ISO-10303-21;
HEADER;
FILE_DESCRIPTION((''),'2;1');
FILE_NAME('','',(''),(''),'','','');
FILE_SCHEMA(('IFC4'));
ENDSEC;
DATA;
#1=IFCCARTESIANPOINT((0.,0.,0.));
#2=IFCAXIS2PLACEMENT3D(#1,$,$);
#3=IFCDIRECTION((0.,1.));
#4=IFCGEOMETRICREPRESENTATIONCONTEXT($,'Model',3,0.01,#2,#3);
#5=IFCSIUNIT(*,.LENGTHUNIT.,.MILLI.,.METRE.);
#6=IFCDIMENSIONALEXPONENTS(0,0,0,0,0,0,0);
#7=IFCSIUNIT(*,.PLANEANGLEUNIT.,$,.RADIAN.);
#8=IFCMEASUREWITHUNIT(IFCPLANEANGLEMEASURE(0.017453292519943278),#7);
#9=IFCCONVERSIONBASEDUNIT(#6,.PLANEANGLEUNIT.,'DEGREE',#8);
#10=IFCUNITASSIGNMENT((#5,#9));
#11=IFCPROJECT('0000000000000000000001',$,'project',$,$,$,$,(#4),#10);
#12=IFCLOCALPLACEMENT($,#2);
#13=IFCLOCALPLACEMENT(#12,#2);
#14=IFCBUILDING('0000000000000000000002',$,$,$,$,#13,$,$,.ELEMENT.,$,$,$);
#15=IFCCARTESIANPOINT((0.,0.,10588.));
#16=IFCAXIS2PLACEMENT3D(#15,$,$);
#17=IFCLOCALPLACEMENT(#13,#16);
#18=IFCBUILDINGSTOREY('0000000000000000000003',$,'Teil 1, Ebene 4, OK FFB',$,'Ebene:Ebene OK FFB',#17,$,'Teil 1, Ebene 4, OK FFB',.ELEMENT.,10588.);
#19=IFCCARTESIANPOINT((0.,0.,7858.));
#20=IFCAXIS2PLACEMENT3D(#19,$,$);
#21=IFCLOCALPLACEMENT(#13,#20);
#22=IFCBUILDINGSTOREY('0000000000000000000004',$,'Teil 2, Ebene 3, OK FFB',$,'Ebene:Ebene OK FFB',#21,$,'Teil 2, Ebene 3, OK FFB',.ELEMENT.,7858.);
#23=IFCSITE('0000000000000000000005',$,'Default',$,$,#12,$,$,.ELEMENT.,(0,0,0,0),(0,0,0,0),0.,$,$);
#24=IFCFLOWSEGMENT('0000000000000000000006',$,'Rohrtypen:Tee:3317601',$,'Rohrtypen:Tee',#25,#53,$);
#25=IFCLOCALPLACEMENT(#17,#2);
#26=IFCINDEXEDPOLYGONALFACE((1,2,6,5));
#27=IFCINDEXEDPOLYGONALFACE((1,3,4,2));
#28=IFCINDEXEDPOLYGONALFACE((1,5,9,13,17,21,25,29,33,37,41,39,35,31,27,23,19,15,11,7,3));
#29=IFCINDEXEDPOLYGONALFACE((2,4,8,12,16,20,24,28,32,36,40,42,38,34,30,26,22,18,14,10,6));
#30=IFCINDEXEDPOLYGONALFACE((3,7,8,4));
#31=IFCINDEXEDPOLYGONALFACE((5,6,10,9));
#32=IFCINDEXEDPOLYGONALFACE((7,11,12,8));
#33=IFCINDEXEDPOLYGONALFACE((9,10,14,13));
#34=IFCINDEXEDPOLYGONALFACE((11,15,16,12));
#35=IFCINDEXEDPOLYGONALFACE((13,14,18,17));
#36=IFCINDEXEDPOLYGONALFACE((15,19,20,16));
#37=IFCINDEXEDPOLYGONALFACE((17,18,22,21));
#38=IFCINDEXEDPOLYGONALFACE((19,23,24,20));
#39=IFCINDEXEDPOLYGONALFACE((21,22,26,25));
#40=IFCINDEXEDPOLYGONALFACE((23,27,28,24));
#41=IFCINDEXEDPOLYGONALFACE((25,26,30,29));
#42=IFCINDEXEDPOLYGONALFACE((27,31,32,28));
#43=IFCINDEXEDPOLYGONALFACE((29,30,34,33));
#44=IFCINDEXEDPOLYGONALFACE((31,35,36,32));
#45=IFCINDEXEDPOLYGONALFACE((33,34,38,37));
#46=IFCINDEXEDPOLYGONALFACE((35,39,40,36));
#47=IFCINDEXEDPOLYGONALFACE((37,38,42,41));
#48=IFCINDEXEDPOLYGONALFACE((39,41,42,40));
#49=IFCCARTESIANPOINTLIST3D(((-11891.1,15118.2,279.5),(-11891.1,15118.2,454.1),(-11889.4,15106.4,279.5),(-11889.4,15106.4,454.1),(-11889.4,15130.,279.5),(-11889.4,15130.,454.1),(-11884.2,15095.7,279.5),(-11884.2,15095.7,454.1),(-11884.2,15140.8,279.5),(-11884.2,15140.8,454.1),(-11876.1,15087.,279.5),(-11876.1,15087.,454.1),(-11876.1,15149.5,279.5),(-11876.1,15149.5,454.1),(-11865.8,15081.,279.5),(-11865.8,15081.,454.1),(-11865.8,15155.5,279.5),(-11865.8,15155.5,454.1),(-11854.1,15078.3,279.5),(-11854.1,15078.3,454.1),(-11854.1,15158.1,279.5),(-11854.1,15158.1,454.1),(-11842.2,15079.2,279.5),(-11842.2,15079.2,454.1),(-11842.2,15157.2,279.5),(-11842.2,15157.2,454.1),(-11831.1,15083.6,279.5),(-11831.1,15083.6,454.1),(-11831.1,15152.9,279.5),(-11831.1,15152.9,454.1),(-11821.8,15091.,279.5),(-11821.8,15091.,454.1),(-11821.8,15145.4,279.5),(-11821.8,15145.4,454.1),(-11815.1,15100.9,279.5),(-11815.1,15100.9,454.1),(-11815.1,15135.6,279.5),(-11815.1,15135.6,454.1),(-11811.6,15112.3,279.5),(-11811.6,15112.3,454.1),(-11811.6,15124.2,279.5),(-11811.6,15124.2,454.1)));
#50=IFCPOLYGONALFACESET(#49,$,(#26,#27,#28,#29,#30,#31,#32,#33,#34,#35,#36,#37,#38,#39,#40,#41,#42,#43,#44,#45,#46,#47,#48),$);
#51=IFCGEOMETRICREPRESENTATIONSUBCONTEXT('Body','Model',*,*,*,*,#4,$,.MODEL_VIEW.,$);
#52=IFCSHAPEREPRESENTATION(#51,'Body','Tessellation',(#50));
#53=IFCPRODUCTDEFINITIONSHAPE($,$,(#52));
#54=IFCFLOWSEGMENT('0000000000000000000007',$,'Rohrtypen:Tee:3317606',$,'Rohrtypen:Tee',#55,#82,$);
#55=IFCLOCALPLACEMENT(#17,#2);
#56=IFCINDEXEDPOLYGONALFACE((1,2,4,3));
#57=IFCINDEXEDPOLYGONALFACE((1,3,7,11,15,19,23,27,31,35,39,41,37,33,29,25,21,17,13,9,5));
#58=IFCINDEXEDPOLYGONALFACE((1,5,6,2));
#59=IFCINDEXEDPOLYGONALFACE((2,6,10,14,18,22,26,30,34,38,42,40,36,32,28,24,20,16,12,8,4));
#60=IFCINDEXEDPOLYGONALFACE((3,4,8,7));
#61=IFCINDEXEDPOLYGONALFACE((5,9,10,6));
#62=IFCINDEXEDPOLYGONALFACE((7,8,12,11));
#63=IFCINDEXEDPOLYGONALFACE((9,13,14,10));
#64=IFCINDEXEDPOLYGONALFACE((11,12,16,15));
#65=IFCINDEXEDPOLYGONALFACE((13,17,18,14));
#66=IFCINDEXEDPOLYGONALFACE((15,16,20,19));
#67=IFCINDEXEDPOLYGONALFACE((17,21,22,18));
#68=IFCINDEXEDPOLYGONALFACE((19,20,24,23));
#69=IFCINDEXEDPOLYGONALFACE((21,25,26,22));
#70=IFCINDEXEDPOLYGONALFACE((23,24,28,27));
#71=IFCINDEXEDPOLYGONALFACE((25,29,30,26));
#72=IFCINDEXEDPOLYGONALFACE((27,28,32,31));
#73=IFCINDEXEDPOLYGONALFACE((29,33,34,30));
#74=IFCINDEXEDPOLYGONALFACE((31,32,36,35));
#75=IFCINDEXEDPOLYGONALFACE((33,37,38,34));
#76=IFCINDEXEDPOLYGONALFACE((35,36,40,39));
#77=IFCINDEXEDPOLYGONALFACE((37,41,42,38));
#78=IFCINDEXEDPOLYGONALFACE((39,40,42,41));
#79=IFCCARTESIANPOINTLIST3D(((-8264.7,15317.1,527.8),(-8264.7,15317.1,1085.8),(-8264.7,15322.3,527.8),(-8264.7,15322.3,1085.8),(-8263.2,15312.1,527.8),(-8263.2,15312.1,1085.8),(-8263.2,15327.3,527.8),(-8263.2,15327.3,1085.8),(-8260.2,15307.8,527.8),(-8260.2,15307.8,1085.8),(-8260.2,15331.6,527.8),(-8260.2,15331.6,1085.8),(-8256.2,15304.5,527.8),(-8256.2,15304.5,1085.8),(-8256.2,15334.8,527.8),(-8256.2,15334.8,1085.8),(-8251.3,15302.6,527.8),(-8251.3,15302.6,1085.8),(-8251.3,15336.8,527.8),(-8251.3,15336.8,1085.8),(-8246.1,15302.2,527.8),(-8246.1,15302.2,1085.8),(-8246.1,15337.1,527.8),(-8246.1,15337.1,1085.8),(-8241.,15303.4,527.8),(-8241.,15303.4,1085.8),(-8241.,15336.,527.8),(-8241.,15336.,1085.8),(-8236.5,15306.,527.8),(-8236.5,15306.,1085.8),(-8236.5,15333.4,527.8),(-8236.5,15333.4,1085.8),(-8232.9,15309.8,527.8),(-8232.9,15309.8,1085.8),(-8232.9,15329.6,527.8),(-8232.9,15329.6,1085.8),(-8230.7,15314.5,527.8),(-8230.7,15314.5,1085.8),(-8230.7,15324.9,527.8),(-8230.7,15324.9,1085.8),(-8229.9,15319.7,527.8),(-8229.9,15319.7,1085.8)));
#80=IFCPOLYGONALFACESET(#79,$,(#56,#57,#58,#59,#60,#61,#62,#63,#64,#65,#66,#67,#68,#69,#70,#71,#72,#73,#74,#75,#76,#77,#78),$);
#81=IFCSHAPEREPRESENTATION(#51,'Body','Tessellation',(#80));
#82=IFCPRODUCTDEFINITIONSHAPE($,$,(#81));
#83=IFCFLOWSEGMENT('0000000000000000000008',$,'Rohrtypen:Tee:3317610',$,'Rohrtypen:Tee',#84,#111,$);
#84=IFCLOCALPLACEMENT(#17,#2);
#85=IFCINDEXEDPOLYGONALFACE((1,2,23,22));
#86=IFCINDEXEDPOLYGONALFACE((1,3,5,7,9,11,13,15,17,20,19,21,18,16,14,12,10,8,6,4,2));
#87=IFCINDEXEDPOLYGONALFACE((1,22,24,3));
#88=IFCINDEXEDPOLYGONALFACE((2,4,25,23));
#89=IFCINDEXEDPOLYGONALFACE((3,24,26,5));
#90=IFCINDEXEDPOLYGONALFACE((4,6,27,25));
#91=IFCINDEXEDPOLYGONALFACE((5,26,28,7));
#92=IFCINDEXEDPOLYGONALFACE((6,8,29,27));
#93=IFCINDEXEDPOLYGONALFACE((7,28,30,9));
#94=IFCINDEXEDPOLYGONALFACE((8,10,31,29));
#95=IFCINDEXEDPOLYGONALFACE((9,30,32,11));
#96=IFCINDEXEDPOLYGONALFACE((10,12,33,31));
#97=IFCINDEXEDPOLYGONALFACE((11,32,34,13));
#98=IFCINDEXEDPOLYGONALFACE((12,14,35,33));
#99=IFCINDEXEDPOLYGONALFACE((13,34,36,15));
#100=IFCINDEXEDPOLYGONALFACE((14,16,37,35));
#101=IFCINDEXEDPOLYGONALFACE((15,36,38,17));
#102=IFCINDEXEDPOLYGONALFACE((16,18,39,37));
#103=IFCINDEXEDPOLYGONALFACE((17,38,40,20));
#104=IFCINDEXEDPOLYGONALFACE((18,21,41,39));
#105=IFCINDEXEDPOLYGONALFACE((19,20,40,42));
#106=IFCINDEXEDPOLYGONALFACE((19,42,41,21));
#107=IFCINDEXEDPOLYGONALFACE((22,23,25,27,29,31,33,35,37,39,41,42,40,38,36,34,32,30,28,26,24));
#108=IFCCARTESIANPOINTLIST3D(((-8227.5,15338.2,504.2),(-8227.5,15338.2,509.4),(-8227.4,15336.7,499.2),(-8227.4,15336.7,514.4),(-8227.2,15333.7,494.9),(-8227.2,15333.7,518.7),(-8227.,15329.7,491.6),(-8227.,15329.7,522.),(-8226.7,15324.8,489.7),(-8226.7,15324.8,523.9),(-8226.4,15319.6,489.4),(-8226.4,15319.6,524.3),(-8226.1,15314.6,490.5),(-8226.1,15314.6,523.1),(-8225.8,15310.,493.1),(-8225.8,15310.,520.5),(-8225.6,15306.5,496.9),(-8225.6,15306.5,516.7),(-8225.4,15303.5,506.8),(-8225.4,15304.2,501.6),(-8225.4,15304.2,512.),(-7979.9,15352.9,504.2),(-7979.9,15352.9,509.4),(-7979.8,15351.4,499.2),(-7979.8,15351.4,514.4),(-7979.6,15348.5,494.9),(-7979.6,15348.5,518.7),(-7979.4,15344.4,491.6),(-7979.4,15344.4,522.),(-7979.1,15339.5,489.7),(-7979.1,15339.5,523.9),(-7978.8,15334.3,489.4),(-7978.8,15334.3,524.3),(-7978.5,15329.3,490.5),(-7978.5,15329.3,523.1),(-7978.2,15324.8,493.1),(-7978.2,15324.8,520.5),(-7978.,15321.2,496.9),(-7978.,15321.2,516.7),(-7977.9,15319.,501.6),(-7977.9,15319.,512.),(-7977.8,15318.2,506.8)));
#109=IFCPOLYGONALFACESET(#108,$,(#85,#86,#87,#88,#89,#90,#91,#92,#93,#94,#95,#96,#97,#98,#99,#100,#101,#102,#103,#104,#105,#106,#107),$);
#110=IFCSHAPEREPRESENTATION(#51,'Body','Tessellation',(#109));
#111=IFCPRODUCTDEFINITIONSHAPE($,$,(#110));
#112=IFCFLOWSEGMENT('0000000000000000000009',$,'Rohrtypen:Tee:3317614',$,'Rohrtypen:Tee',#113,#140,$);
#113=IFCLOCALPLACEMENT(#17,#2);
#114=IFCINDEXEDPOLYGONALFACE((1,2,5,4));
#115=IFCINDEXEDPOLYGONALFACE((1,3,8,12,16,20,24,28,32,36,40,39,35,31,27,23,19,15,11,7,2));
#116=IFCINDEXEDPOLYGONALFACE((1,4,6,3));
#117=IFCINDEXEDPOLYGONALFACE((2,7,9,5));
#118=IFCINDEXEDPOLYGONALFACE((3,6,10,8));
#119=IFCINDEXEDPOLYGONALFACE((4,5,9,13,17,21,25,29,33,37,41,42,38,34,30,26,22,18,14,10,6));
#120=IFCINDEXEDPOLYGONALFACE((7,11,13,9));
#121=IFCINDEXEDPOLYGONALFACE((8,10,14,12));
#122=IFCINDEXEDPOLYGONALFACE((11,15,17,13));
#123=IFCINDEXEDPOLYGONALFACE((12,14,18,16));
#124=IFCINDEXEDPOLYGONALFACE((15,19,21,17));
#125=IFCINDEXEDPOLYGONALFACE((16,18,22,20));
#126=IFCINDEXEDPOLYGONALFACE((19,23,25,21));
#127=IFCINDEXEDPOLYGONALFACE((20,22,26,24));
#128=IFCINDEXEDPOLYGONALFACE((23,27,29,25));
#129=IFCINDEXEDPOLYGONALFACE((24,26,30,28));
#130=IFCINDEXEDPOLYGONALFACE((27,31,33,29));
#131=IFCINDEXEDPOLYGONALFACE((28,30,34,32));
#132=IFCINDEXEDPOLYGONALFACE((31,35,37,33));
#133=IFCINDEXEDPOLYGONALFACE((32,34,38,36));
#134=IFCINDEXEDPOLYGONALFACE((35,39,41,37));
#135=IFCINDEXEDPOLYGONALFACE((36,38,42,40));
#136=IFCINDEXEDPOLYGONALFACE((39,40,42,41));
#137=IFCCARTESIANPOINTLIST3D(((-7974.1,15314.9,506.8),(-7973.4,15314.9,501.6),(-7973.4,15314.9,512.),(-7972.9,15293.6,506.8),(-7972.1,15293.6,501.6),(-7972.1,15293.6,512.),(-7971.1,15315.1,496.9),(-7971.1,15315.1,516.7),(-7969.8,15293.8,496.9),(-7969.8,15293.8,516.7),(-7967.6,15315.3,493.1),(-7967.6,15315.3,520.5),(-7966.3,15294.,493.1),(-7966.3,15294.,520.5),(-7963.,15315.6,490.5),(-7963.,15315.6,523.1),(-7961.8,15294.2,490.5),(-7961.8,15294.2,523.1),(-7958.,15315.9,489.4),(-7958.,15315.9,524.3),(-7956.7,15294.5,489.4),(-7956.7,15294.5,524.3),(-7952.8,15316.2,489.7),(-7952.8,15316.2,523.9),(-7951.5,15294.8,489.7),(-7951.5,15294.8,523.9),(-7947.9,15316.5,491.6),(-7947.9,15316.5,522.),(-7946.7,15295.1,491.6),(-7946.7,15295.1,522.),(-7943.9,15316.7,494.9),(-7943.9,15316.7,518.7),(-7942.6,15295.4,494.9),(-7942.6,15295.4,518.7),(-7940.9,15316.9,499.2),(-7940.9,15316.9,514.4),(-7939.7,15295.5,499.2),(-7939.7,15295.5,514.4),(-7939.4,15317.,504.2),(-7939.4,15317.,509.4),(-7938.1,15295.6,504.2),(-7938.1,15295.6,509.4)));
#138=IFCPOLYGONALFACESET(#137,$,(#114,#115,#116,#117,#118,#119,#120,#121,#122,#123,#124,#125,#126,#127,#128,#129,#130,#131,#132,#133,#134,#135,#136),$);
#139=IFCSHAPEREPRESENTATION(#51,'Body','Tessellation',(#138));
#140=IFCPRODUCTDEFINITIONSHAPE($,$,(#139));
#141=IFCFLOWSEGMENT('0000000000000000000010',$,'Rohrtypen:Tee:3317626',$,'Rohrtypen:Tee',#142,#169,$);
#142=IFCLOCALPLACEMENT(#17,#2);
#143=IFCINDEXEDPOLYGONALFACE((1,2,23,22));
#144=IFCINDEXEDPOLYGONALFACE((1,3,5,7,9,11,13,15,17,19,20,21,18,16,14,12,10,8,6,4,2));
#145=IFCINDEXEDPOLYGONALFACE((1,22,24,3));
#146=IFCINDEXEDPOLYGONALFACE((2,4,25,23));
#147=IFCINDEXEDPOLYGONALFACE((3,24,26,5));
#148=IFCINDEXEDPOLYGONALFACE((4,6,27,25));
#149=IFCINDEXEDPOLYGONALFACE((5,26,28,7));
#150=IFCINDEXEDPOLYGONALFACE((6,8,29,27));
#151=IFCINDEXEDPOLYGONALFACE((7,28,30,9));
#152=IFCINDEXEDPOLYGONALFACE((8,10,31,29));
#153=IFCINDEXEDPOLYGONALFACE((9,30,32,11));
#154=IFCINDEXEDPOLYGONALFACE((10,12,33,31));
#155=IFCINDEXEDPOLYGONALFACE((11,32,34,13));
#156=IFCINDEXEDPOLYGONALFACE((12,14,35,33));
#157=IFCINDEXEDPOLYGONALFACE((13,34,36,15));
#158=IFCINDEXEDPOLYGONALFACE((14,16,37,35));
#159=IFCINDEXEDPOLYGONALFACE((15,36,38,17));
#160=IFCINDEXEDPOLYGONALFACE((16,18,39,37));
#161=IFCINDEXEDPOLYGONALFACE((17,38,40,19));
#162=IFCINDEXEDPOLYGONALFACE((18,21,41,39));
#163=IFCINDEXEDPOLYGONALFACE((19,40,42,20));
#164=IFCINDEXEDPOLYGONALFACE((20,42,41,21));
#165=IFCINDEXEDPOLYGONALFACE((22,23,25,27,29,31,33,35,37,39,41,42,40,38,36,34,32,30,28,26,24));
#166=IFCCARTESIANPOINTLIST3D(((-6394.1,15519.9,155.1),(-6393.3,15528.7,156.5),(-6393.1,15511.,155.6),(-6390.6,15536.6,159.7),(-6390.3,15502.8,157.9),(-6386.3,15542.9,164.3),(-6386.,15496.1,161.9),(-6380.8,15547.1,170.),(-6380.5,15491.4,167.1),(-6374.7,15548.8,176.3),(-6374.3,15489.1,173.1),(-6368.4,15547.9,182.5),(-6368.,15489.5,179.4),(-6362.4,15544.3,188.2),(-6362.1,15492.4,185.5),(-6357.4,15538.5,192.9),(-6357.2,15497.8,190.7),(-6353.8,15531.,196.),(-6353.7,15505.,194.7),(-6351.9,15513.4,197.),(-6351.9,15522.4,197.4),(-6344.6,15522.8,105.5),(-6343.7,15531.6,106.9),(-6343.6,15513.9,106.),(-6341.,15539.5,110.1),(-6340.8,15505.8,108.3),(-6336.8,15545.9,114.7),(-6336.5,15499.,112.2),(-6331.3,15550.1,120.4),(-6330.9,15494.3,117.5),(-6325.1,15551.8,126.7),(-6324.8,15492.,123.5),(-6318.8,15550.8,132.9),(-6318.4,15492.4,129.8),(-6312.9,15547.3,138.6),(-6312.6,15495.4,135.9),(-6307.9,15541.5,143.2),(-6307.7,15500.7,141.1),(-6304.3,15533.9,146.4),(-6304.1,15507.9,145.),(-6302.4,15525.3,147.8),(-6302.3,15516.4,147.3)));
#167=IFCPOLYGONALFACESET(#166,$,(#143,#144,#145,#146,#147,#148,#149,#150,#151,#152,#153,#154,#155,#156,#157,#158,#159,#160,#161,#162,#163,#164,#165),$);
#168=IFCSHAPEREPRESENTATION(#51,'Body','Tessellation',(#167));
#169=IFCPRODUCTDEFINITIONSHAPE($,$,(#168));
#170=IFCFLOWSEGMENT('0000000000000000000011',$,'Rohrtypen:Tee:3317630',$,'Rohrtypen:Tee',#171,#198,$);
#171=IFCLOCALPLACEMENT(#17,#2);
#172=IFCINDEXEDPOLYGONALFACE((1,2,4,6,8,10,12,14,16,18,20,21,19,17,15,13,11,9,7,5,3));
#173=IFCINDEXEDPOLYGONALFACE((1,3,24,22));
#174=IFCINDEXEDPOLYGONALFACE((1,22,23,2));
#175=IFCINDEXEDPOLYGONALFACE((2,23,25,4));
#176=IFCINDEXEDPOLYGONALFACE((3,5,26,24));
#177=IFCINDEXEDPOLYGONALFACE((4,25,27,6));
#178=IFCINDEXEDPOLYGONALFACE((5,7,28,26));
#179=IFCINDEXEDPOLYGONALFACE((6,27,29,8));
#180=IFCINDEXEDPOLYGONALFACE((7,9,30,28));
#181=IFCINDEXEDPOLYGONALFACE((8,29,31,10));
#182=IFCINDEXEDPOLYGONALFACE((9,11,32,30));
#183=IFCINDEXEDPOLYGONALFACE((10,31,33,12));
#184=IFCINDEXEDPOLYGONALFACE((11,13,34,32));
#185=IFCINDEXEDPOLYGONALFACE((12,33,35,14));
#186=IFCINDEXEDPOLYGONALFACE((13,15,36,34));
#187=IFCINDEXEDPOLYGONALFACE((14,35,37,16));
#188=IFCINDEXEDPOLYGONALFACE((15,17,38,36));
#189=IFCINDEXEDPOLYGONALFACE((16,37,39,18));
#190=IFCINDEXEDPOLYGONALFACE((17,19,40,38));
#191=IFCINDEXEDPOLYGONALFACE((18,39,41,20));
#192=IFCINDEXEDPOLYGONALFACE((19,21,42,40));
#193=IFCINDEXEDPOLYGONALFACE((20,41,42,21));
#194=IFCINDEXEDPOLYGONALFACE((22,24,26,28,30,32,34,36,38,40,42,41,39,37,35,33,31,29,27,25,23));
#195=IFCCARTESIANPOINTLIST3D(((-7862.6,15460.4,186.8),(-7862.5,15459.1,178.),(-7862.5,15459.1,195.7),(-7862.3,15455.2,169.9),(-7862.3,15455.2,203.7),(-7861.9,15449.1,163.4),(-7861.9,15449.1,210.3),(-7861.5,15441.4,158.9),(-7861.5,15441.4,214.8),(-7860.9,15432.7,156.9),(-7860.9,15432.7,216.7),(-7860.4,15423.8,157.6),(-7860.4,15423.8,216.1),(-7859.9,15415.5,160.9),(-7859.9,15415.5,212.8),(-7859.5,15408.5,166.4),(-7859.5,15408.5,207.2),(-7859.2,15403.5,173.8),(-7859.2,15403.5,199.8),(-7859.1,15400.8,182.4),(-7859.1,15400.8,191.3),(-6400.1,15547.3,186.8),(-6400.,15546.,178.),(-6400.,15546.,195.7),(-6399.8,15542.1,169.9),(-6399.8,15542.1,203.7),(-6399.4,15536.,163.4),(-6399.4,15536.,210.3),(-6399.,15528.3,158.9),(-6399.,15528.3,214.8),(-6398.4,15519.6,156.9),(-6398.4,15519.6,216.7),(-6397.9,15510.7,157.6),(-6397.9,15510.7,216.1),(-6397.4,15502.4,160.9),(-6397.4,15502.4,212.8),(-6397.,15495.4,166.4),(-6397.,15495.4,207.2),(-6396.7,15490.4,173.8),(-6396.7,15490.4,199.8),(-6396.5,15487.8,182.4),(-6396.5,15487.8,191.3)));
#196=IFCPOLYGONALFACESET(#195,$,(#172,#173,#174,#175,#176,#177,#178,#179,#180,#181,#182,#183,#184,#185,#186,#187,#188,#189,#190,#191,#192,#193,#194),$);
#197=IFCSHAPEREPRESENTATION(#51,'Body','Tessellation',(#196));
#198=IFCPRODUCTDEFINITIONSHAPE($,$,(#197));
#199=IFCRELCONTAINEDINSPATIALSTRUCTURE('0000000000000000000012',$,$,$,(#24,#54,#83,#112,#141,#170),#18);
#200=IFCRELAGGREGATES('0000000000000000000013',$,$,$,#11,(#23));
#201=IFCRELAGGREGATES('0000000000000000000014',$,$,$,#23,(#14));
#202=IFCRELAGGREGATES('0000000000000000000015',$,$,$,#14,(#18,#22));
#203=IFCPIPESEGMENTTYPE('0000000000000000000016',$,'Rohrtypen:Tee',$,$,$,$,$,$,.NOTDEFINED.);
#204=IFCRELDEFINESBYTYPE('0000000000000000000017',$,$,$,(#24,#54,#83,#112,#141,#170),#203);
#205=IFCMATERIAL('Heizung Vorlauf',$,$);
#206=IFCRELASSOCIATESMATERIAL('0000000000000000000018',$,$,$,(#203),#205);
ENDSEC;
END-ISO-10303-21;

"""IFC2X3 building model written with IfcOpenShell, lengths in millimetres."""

from ifc_helpers import new_model, entity, si_unit, converted_unit, direction, frame, frame_2d, origin, origin_2d_with_axis, place, context, subcontext, project, spatial, circle, extrude, material, type_object, element, save


model = new_model("IFC2X3")

# Units and contexts
model_context = context("Model", 3, precision=0.01, world=origin(), true_north=direction((0.0, 1.0)))
body_context = subcontext(model_context, "Body", "Model", "MODEL_VIEW")
ifc_project = project(units=[si_unit("LENGTHUNIT", "METRE", prefix="MILLI"), converted_unit("PLANEANGLEUNIT", "DEGREE", entity("IfcPlaneAngleMeasure", 0.017453292519943278), si_unit("PLANEANGLEUNIT", "RADIAN"), dimensions=[0, 0, 0, 0, 0, 0, 0])], contexts=[model_context])

# Site, building, storey
site_placement = place(None, origin())
site = spatial("IfcSite", under=ifc_project, at=site_placement, Name="Default", CompositionType="ELEMENT", RefLatitude=(0, 0, 0, 0), RefLongitude=(0, 0, 0, 0), RefElevation=0.0)
building_placement = place(site_placement, origin())
building = spatial("IfcBuilding", under=site, at=building_placement, CompositionType="ELEMENT")
storey_1_placement = place(building_placement, frame((0.0, 0.0, 10588.0)))
storey_1 = spatial("IfcBuildingStorey", under=building, at=storey_1_placement, Name="Teil 1, Ebene 4, OK FFB", ObjectType="Ebene:Ebene OK FFB", LongName="Teil 1, Ebene 4, OK FFB", CompositionType="ELEMENT", Elevation=10588.0)

# Shared definitions
storey_2_placement = place(building_placement, frame((0.0, 0.0, 7858.0)))
storey_2 = spatial("IfcBuildingStorey", under=building, at=storey_2_placement, Name="Teil 2, Ebene 3, OK FFB", ObjectType="Ebene:Ebene OK FFB", LongName="Teil 2, Ebene 3, OK FFB", CompositionType="ELEMENT", Elevation=7858.0)

# Flow segments
ifc_material_1 = material(Name="Heizung Vorlauf")
pipe_segment_type = type_object("IfcPipeSegmentType", Name="Rohrtypen:Tee", PredefinedType="NOTDEFINED", material=ifc_material_1)
flow_segment_1_placement = place(storey_1_placement, origin())
element("IfcFlowSegment", 1, at=flow_segment_1_placement, inside=storey_1, type_object=pipe_segment_type, Name="Rohrtypen:Tee:3317601", ObjectType="Rohrtypen:Tee", context=body_context, shape_type="SweptSolid", body=[
    extrude(circle(Radius=40.0, at=origin_2d_with_axis()), frame((-11851.1, 15118.2, 279.5), z_axis=(0.0, 0.0, 1.0), x_axis=(-1.0, 0.0, 0.0)), (0.0, 0.0, 1.0), 174.6),
])
flow_segment_2_placement = place(storey_1_placement, origin())
element("IfcFlowSegment", 2, at=flow_segment_2_placement, inside=storey_1, type_object=pipe_segment_type, Name="Rohrtypen:Tee:3317606", ObjectType="Rohrtypen:Tee", context=body_context, shape_type="SweptSolid", body=[
    extrude(circle(Radius=17.5, at=origin_2d_with_axis()), frame((-8247.4, 15319.7, 527.8)), (0.0, 0.0, 1.0), 558.0),
])
flow_segment_3_placement = place(storey_1_placement, origin())
element("IfcFlowSegment", 3, at=flow_segment_3_placement, inside=storey_1, type_object=pipe_segment_type, Name="Rohrtypen:Tee:3317610", ObjectType="Rohrtypen:Tee", context=body_context, shape_type="SweptSolid", body=[
    extrude(circle(Radius=17.5, at=origin_2d_with_axis()), frame((-8226.4, 15320.9, 506.8), z_axis=(0.998239, 0.059319, 0.0), x_axis=(0.059319, -0.998239, 0.0)), (0.0, 0.0, 1.0), 248.0),
])
flow_segment_4_placement = place(storey_1_placement, origin())
element("IfcFlowSegment", 4, at=flow_segment_4_placement, inside=storey_1, type_object=pipe_segment_type, Name="Rohrtypen:Tee:3317614", ObjectType="Rohrtypen:Tee", context=body_context, shape_type="SweptSolid", body=[
    extrude(circle(Radius=17.5, at=frame_2d((0.0, 0.0), x_axis=(1.0, 0.0))), frame((-7956.7, 15315.9, 506.8), z_axis=(0.059319, -0.998239, 0.0), x_axis=(-0.998239, -0.059319, 0.0)), (0.0, 0.0, 1.0), 21.4),
])
flow_segment_5_placement = place(storey_1_placement, origin())
element("IfcFlowSegment", 5, at=flow_segment_5_placement, inside=storey_1, type_object=pipe_segment_type, Name="Rohrtypen:Tee:3317626", ObjectType="Rohrtypen:Tee", context=body_context, shape_type="SweptSolid", body=[
    extrude(circle(Radius=30.0, at=frame_2d((0.0, 0.0), x_axis=(1.0, 0.0))), frame((-6323.4, 15521.8, 126.7), z_axis=(-0.705862, -0.041945, 0.707107), x_axis=(-0.059319, 0.998239, 0.0)), (0.0, 0.0, 1.0), 70.2),
])
flow_segment_6_placement = place(storey_1_placement, origin())
element("IfcFlowSegment", 6, at=flow_segment_6_placement, inside=storey_1, type_object=pipe_segment_type, Name="Rohrtypen:Tee:3317630", ObjectType="Rohrtypen:Tee", context=body_context, shape_type="SweptSolid", body=[
    extrude(circle(Radius=30.0, at=origin_2d_with_axis()), frame((-7860.8, 15430.5, 186.8), z_axis=(0.998239, 0.059319, 0.0), x_axis=(-0.059319, 0.998239, 0.0)), (0.0, 0.0, 1.0), 1465.1),
])

save(model, "model.ifc")
